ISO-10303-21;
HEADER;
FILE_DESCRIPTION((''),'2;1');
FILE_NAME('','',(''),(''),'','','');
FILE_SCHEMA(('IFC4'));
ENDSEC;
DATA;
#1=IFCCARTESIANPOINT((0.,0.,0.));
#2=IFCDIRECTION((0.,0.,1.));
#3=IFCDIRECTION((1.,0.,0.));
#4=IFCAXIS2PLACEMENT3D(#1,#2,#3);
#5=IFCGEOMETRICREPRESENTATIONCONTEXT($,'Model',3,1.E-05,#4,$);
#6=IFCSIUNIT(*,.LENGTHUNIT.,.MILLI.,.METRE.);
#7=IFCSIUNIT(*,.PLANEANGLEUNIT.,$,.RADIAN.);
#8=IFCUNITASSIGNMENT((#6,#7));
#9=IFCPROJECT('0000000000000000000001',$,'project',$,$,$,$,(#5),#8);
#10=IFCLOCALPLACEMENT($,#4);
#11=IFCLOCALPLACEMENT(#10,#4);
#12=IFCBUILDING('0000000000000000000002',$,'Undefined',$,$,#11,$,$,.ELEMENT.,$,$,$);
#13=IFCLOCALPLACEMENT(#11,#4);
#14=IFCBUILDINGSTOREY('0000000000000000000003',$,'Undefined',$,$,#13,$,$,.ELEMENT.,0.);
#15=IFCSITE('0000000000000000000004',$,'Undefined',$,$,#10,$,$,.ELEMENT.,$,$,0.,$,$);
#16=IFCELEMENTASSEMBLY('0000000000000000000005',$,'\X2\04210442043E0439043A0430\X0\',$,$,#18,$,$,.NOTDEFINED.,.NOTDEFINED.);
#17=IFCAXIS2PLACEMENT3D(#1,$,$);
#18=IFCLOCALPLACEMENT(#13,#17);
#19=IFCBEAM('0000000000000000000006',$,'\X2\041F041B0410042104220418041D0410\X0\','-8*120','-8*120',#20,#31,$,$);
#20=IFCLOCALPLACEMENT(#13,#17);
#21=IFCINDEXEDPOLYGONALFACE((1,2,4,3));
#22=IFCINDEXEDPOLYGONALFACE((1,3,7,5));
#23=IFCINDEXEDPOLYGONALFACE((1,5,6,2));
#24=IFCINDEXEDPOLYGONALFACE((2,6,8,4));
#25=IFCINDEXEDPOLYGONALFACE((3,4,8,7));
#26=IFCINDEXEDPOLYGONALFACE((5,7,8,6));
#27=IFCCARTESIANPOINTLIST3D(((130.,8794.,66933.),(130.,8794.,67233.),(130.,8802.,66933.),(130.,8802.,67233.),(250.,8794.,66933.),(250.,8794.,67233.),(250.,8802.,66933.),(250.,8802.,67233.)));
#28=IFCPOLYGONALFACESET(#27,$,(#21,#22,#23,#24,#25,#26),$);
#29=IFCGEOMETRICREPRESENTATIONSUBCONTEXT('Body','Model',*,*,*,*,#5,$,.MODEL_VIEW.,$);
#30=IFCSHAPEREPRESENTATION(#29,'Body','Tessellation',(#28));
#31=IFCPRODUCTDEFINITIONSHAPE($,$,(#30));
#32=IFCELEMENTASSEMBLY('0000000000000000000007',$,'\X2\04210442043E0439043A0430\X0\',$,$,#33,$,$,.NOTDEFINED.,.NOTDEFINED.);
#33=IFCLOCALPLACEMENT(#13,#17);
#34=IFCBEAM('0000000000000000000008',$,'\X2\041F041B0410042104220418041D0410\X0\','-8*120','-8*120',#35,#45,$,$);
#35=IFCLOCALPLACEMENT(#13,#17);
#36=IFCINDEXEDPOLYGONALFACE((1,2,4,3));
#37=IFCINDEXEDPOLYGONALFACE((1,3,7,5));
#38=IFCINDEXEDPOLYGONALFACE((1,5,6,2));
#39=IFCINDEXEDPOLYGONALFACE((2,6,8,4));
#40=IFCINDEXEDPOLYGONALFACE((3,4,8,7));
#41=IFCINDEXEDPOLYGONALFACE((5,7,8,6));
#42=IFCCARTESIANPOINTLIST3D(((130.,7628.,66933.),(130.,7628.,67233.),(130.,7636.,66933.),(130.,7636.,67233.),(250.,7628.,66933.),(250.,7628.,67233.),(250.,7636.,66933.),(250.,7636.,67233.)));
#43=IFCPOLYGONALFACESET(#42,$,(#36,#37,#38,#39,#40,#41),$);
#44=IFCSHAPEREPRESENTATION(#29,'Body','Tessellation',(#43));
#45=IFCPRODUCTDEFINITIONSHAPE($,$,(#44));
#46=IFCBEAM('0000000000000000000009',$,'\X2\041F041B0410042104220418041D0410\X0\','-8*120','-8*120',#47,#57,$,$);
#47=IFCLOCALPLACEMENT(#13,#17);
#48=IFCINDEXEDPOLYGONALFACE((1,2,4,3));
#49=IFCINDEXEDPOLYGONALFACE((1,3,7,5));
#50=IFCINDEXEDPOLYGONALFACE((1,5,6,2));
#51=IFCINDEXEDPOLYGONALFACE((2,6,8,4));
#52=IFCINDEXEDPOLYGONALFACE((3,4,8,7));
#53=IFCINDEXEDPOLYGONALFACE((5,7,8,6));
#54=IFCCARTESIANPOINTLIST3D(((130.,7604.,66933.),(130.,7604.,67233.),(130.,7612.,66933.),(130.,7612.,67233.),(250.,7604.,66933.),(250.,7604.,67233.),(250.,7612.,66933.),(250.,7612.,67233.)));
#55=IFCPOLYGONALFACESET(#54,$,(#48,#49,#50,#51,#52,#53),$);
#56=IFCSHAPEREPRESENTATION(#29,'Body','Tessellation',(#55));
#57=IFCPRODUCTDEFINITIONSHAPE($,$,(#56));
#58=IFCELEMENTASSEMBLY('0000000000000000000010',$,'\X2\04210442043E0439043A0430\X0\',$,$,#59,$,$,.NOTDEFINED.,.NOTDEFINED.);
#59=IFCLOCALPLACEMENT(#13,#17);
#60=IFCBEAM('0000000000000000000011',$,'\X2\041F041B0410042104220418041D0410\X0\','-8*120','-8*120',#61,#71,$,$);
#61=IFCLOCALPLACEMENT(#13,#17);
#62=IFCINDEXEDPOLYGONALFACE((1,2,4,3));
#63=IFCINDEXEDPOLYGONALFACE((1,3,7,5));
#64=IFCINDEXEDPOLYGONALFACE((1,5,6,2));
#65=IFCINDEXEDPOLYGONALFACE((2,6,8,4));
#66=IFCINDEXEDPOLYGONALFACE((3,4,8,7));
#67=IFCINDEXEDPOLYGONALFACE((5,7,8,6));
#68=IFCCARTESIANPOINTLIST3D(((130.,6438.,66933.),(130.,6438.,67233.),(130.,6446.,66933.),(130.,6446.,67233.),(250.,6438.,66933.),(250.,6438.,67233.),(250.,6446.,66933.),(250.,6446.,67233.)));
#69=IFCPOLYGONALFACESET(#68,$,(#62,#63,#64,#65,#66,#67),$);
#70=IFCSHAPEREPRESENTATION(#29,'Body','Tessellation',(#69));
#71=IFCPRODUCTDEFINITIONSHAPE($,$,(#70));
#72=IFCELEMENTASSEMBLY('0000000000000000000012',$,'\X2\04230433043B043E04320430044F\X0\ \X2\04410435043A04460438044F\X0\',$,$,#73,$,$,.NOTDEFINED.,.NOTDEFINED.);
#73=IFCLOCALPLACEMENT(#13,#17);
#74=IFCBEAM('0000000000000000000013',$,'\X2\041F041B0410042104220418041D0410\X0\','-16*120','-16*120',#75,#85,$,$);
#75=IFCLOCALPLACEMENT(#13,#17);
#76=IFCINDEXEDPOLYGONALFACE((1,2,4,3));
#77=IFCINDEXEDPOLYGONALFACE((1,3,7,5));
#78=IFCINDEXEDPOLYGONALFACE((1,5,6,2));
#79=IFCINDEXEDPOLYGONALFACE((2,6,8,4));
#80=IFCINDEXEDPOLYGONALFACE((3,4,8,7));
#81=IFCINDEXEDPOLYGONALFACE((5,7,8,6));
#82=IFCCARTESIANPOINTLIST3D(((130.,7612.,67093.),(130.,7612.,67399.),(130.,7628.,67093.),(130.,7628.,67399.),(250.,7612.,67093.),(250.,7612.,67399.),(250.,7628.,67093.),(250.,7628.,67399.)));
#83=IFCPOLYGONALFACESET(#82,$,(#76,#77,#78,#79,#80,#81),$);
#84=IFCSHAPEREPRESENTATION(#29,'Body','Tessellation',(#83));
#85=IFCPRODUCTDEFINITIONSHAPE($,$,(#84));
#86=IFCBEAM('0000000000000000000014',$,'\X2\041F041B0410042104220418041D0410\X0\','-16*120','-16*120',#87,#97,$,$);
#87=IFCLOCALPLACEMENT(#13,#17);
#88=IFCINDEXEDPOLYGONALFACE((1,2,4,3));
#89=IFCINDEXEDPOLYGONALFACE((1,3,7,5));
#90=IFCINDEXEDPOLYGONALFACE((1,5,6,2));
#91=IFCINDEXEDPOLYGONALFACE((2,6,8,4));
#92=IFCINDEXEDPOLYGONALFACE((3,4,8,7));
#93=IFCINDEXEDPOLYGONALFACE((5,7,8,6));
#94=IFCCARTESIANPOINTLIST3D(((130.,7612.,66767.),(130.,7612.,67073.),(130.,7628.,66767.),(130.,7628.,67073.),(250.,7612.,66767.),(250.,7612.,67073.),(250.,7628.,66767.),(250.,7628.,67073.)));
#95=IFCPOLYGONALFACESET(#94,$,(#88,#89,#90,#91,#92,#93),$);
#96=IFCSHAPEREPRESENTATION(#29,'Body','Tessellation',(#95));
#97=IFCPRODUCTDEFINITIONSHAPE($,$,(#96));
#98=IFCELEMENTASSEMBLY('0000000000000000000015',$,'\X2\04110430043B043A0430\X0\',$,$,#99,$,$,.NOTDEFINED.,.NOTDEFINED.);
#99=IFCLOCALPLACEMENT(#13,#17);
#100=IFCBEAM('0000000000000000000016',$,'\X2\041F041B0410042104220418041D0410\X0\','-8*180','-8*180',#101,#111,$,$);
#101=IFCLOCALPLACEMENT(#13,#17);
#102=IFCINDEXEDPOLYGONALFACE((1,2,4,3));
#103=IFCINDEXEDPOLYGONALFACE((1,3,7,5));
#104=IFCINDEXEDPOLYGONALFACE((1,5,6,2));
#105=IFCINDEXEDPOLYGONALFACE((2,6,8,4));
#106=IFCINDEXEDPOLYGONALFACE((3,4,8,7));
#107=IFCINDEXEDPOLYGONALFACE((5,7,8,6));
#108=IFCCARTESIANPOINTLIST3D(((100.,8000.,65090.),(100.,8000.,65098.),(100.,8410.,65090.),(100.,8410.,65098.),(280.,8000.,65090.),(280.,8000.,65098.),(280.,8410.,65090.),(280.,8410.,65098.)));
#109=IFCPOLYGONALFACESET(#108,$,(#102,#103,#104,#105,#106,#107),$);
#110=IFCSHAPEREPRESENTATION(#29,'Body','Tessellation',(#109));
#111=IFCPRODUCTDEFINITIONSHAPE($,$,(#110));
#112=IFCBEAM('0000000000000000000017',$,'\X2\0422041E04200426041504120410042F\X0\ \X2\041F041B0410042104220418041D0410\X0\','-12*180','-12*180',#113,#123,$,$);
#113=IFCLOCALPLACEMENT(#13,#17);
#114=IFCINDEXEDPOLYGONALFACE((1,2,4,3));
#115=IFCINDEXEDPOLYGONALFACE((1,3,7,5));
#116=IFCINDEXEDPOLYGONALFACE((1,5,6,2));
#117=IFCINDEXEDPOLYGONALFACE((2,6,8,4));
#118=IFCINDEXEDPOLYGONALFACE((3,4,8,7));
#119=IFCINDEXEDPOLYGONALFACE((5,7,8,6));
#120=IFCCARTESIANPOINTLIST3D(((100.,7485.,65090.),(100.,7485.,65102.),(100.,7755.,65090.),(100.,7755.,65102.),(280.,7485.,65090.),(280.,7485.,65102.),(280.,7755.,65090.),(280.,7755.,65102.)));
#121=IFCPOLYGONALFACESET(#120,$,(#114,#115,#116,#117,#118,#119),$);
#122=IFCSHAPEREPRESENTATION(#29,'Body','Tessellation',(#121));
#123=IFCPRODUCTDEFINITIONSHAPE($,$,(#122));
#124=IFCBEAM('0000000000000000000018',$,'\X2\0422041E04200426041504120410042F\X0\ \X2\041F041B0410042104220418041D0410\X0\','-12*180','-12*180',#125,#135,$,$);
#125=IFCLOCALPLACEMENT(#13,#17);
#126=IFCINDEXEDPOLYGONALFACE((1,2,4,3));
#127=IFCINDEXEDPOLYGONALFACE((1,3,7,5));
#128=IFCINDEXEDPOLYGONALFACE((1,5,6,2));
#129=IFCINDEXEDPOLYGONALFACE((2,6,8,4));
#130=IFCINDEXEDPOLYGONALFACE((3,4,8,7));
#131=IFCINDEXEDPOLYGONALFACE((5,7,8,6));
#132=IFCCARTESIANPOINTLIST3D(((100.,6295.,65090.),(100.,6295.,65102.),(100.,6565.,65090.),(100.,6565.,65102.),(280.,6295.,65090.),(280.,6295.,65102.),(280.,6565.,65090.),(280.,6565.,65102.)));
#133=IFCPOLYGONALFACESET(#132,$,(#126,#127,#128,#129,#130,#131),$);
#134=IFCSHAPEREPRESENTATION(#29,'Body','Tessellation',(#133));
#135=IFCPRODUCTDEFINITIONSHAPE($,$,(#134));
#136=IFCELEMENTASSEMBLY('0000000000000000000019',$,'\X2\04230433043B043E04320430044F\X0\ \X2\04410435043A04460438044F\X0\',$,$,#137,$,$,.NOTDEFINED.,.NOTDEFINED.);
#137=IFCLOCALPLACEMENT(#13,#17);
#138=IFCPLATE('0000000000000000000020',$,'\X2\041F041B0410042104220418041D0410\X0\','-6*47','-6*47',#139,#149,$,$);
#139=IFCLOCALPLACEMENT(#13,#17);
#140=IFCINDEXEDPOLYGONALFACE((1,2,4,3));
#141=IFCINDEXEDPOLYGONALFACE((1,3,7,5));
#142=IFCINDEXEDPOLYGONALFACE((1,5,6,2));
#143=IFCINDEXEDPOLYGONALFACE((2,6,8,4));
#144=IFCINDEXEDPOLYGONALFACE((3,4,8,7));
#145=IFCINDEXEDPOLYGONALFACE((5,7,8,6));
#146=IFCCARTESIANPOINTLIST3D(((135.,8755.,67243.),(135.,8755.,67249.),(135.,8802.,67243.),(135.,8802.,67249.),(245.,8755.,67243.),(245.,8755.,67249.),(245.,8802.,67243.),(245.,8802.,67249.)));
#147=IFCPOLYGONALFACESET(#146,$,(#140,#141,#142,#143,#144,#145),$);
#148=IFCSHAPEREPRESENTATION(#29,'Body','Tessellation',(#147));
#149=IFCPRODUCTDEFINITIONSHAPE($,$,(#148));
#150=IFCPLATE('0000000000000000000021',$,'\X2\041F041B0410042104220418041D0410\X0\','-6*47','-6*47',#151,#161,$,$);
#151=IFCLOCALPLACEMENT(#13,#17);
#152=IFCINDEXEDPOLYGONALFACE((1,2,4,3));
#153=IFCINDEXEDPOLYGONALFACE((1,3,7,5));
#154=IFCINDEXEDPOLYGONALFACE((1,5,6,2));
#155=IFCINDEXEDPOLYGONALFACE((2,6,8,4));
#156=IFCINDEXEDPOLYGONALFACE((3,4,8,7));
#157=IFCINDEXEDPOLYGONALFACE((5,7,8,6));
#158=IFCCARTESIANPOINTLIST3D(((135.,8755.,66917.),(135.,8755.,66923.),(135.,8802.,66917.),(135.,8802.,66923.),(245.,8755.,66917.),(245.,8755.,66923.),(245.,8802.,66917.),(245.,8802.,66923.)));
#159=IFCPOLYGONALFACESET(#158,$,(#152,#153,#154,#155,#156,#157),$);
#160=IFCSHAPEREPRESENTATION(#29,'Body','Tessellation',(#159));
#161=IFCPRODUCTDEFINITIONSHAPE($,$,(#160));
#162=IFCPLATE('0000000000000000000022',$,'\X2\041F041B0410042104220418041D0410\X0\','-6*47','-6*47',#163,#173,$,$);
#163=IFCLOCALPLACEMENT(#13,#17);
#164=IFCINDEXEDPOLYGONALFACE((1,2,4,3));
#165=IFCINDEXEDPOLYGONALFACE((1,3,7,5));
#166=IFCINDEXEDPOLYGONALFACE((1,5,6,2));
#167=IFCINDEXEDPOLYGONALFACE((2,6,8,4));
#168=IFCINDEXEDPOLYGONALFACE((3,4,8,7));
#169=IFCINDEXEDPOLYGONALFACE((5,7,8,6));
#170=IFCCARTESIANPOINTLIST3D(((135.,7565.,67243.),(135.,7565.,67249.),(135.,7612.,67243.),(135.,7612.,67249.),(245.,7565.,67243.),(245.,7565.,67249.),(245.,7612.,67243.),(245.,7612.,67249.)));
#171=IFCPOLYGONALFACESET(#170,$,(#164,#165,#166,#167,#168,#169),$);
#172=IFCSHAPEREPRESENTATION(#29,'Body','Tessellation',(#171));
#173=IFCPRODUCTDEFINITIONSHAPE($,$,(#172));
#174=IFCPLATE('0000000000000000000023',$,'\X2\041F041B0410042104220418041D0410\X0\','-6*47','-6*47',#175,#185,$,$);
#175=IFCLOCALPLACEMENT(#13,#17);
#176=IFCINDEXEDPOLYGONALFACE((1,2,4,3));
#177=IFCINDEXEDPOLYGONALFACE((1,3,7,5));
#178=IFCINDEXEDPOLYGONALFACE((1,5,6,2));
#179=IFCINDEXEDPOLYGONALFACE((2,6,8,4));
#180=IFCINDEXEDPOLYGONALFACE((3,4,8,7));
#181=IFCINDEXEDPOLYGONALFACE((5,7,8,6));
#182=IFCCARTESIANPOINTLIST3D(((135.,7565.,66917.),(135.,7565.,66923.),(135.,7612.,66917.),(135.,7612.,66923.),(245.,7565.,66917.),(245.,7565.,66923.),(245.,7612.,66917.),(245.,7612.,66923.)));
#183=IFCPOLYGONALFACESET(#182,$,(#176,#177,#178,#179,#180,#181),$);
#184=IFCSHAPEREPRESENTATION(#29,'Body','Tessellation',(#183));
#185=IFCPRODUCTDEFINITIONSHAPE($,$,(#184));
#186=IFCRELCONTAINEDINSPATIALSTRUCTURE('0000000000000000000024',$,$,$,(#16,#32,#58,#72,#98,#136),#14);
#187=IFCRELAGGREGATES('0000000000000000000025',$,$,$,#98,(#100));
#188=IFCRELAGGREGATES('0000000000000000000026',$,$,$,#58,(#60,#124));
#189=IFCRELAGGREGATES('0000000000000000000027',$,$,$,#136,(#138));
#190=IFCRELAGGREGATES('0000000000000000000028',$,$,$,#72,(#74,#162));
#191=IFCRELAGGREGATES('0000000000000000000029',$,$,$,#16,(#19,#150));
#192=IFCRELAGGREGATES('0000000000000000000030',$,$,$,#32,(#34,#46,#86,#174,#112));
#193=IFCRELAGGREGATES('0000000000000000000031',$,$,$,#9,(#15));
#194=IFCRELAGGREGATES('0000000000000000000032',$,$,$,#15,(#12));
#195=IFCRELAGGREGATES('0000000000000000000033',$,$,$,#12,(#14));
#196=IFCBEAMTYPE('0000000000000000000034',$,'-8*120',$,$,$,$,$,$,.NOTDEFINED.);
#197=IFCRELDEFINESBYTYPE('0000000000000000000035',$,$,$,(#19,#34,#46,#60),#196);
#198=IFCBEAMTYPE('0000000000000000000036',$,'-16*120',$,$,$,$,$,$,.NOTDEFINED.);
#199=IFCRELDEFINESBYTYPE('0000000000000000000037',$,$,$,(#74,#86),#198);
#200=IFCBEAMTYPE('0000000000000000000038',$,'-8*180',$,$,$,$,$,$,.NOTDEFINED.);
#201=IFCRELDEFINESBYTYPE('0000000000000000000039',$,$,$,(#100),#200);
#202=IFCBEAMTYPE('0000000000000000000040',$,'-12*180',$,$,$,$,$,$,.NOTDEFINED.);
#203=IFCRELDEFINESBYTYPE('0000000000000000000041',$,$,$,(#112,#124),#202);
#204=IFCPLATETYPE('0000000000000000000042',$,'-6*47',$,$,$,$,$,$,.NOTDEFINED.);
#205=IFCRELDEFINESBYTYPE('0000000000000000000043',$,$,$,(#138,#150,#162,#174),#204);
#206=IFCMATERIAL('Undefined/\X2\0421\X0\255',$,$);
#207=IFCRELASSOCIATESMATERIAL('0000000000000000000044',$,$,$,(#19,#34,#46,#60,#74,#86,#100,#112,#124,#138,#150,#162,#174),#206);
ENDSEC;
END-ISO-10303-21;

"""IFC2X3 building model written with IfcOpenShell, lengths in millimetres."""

from ifc_helpers import new_model, si_unit, frame, origin_with_axes, origin_2d_with_axis, place, context, subcontext, project, spatial, polyline, rectangle, outline, extrude, boolean, material, type_object, element, aggregate, save


model = new_model("IFC2X3")

# Units and contexts
model_context = context("Model", 3, precision=1e-05, world=origin_with_axes())
body_context = subcontext(model_context, "Body", "Model", "MODEL_VIEW")
ifc_project = project(units=[si_unit("LENGTHUNIT", "METRE", prefix="MILLI"), si_unit("PLANEANGLEUNIT", "RADIAN")], contexts=[model_context])

# Site, building, storey
site_placement = place(None, origin_with_axes())
site = spatial("IfcSite", under=ifc_project, at=site_placement, Name="Undefined", CompositionType="ELEMENT", RefElevation=0.0)
building_placement = place(site_placement, origin_with_axes())
building = spatial("IfcBuilding", under=site, at=building_placement, Name="Undefined", CompositionType="ELEMENT")
storey_placement = place(building_placement, origin_with_axes())
storey = spatial("IfcBuildingStorey", under=building, at=storey_placement, Name="Undefined", CompositionType="ELEMENT", Elevation=0.0)

# Element assembly, beam
assembly_1_placement = place(storey_placement, origin_with_axes())
assembly_1 = element("IfcElementAssembly", 1, at=assembly_1_placement, inside=storey, Name="Стойка", AssemblyPlace="NOTDEFINED", PredefinedType="NOTDEFINED")
ifc_material_1 = material(Name="Undefined/С255")
beam_type_1 = type_object("IfcBeamType", Name="-8*120", PredefinedType="NOTDEFINED")
beam_1_placement = place(assembly_1_placement, frame((190.0, 8798.0, 66933.0), z_axis=(1.0, 0.0, 0.0), x_axis=(0.0, 0.0, 1.0)))
beam_1 = element("IfcBeam", 2, at=beam_1_placement, type_object=beam_type_1, material=ifc_material_1, Name="ПЛАСТИНА", Description="-8*120", ObjectType="-8*120", context=body_context, shape_type="SweptSolid", body=[
    extrude(rectangle(XDim=8.0, YDim=120.0, at=origin_2d_with_axis()), frame((300.0, 0.0, 0.0), z_axis=(-1.0, 0.0, 0.0), x_axis=(0.0, -1.0, 0.0)), (0.0, 0.0, 1.0), 300.0),
])

# Element assembly, beams
assembly_2_placement = place(storey_placement, origin_with_axes())
assembly_2 = element("IfcElementAssembly", 3, at=assembly_2_placement, inside=storey, Name="Стойка", AssemblyPlace="NOTDEFINED", PredefinedType="NOTDEFINED")
beam_2_placement = place(assembly_2_placement, frame((190.0, 7632.0, 66933.0), z_axis=(1.0, 0.0, 0.0), x_axis=(0.0, 0.0, 1.0)))
beam_2 = element("IfcBeam", 4, at=beam_2_placement, type_object=beam_type_1, material=ifc_material_1, Name="ПЛАСТИНА", Description="-8*120", ObjectType="-8*120", context=body_context, shape_type="SweptSolid", body=[
    extrude(rectangle(XDim=8.0, YDim=120.0, at=origin_2d_with_axis()), frame((300.0, 0.0, 0.0), z_axis=(-1.0, 0.0, 0.0), x_axis=(0.0, -1.0, 0.0)), (0.0, 0.0, 1.0), 300.0),
])
beam_3_placement = place(assembly_2_placement, frame((190.0, 7608.0, 66933.0), z_axis=(1.0, 0.0, 0.0), x_axis=(0.0, 0.0, 1.0)))
beam_3 = element("IfcBeam", 5, at=beam_3_placement, type_object=beam_type_1, material=ifc_material_1, Name="ПЛАСТИНА", Description="-8*120", ObjectType="-8*120", context=body_context, shape_type="SweptSolid", body=[
    extrude(rectangle(XDim=8.0, YDim=120.0, at=origin_2d_with_axis()), frame((300.0, 0.0, 0.0), z_axis=(-1.0, 0.0, 0.0), x_axis=(0.0, -1.0, 0.0)), (0.0, 0.0, 1.0), 300.0),
])

# Element assemblies, beams
assembly_3_placement = place(storey_placement, origin_with_axes())
assembly_3 = element("IfcElementAssembly", 6, at=assembly_3_placement, inside=storey, Name="Стойка", AssemblyPlace="NOTDEFINED", PredefinedType="NOTDEFINED")
beam_4_placement = place(assembly_3_placement, frame((190.0, 6442.0, 66933.0), z_axis=(1.0, 0.0, 0.0), x_axis=(0.0, 0.0, 1.0)))
beam_4 = element("IfcBeam", 7, at=beam_4_placement, type_object=beam_type_1, material=ifc_material_1, Name="ПЛАСТИНА", Description="-8*120", ObjectType="-8*120", context=body_context, shape_type="SweptSolid", body=[
    extrude(rectangle(XDim=8.0, YDim=120.0, at=origin_2d_with_axis()), frame((300.0, 0.0, 0.0), z_axis=(-1.0, 0.0, 0.0), x_axis=(0.0, -1.0, 0.0)), (0.0, 0.0, 1.0), 300.0),
])
assembly_4_placement = place(storey_placement, origin_with_axes())
assembly_4 = element("IfcElementAssembly", 8, at=assembly_4_placement, inside=storey, Name="Угловая секция", AssemblyPlace="NOTDEFINED", PredefinedType="NOTDEFINED")
beam_type_2 = type_object("IfcBeamType", Name="-16*120", PredefinedType="NOTDEFINED")
beam_5_placement = place(assembly_4_placement, frame((190.0, 7620.0, 67093.0), z_axis=(1.0, 0.0, 0.0), x_axis=(0.0, 0.0, 1.0)))
beam_5 = element("IfcBeam", 9, at=beam_5_placement, type_object=beam_type_2, material=ifc_material_1, Name="ПЛАСТИНА", Description="-16*120", ObjectType="-16*120", context=body_context, shape_type="SweptSolid", body=[
    extrude(rectangle(XDim=16.0, YDim=120.0, at=origin_2d_with_axis()), frame((306.0, 0.0, 0.0), z_axis=(-1.0, 0.0, 0.0), x_axis=(0.0, -1.0, 0.0)), (0.0, 0.0, 1.0), 306.0),
])

# Beam
beam_6_placement = place(assembly_2_placement, frame((190.0, 7620.0, 66767.0), z_axis=(1.0, 0.0, 0.0), x_axis=(0.0, 0.0, 1.0)))
beam_6 = element("IfcBeam", 10, at=beam_6_placement, type_object=beam_type_2, material=ifc_material_1, Name="ПЛАСТИНА", Description="-16*120", ObjectType="-16*120", context=body_context, shape_type="SweptSolid", body=[
    extrude(rectangle(XDim=16.0, YDim=120.0, at=origin_2d_with_axis()), frame((306.0, 0.0, 0.0), z_axis=(-1.0, 0.0, 0.0), x_axis=(0.0, -1.0, 0.0)), (0.0, 0.0, 1.0), 306.0),
])

# Element assembly, beam
assembly_5_placement = place(storey_placement, origin_with_axes())
assembly_5 = element("IfcElementAssembly", 11, at=assembly_5_placement, inside=storey, Name="Балка", AssemblyPlace="NOTDEFINED", PredefinedType="NOTDEFINED")
beam_type_3 = type_object("IfcBeamType", Name="-8*180", PredefinedType="NOTDEFINED")
beam_7_placement = place(assembly_5_placement, frame((190.0, 8410.0, 65094.0), z_axis=(-1.0, 0.0, 0.0), x_axis=(0.0, -1.0, 0.0)))
beam_7 = element("IfcBeam", 12, at=beam_7_placement, type_object=beam_type_3, material=ifc_material_1, Name="ПЛАСТИНА", Description="-8*180", ObjectType="-8*180", context=body_context, shape_type="SweptSolid", body=[
    extrude(rectangle(XDim=8.0, YDim=180.0, at=origin_2d_with_axis()), frame((410.0, 0.0, 0.0), z_axis=(-1.0, 0.0, 0.0), x_axis=(0.0, -1.0, 0.0)), (0.0, 0.0, 1.0), 410.0),
])
aggregate(assembly_5, [beam_7])

# Beams
beam_type_4 = type_object("IfcBeamType", Name="-12*180", PredefinedType="NOTDEFINED")
beam_8_placement = place(assembly_2_placement, frame((190.0, 7755.0, 65096.0), z_axis=(1.0, 0.0, 0.0), x_axis=(0.0, -1.0, 0.0)))
beam_8 = element("IfcBeam", 13, at=beam_8_placement, type_object=beam_type_4, material=ifc_material_1, Name="ТОРЦЕВАЯ ПЛАСТИНА", Description="-12*180", ObjectType="-12*180", context=body_context, shape_type="SweptSolid", body=[
    extrude(rectangle(XDim=12.0, YDim=180.0, at=origin_2d_with_axis()), frame((270.0, 0.0, 0.0), z_axis=(-1.0, 0.0, 0.0), x_axis=(0.0, -1.0, 0.0)), (0.0, 0.0, 1.0), 270.0),
])
beam_9_placement = place(assembly_3_placement, frame((190.0, 6565.0, 65096.0), z_axis=(1.0, 0.0, 0.0), x_axis=(0.0, -1.0, 0.0)))
beam_9 = element("IfcBeam", 14, at=beam_9_placement, type_object=beam_type_4, material=ifc_material_1, Name="ТОРЦЕВАЯ ПЛАСТИНА", Description="-12*180", ObjectType="-12*180", context=body_context, shape_type="SweptSolid", body=[
    extrude(rectangle(XDim=12.0, YDim=180.0, at=origin_2d_with_axis()), frame((270.0, 0.0, 0.0), z_axis=(-1.0, 0.0, 0.0), x_axis=(0.0, -1.0, 0.0)), (0.0, 0.0, 1.0), 270.0),
])
aggregate(assembly_3, [beam_4, beam_9])

# Element assembly, plate
assembly_6_placement = place(storey_placement, origin_with_axes())
assembly_6 = element("IfcElementAssembly", 15, at=assembly_6_placement, inside=storey, Name="Угловая секция", AssemblyPlace="NOTDEFINED", PredefinedType="NOTDEFINED")
plate_type = type_object("IfcPlateType", Name="-6*47", PredefinedType="NOTDEFINED")
plate_1_placement = place(assembly_6_placement, frame((245.0, 8755.0, 67246.0), z_axis=(0.0, 0.0, -1.0), x_axis=(-1.0, 0.0, 0.0)))
plate_1 = element("IfcPlate", 16, at=plate_1_placement, type_object=plate_type, material=ifc_material_1, Name="ПЛАСТИНА", Description="-6*47", ObjectType="-6*47", context=body_context, shape_type="CSG", body=[
    boolean("DIFFERENCE", extrude(outline(polyline([(0.0, 0.0), (110.0, 0.0), (110.0, 110.0), (0.0, 110.0), (0.0, 0.0)])), frame((0.0, 0.0, -3.0), z_axis=(0.0, 0.0, 1.0), x_axis=(1.0, 0.0, 0.0)), (0.0, 0.0, 1.0), 6.0), extrude(rectangle(XDim=26.0, YDim=130.0, at=origin_2d_with_axis()), frame((55.0, 47.0, 0.0), z_axis=(0.0, 1.0, 0.0), x_axis=(0.0, 0.0, -1.0)), (0.0, 0.0, 1.0), 66.0)),
])
aggregate(assembly_6, [plate_1])

# Plates
plate_2_placement = place(assembly_1_placement, frame((135.0, 8755.0, 66920.0), z_axis=(0.0, 0.0, 1.0), x_axis=(1.0, 0.0, 0.0)))
plate_2 = element("IfcPlate", 17, at=plate_2_placement, type_object=plate_type, material=ifc_material_1, Name="ПЛАСТИНА", Description="-6*47", ObjectType="-6*47", context=body_context, shape_type="CSG", body=[
    boolean("DIFFERENCE", extrude(outline(polyline([(0.0, 0.0), (110.0, 0.0), (110.0, 110.0), (0.0, 110.0), (0.0, 0.0)])), frame((0.0, 0.0, -3.0), z_axis=(0.0, 0.0, 1.0), x_axis=(1.0, 0.0, 0.0)), (0.0, 0.0, 1.0), 6.0), extrude(rectangle(XDim=26.0, YDim=130.0, at=origin_2d_with_axis()), frame((55.0, 47.0, 0.0), z_axis=(0.0, 1.0, 0.0), x_axis=(0.0, 0.0, -1.0)), (0.0, 0.0, 1.0), 66.0)),
])
plate_3_placement = place(assembly_4_placement, frame((245.0, 7565.0, 67246.0), z_axis=(0.0, 0.0, -1.0), x_axis=(-1.0, 0.0, 0.0)))
plate_3 = element("IfcPlate", 18, at=plate_3_placement, type_object=plate_type, material=ifc_material_1, Name="ПЛАСТИНА", Description="-6*47", ObjectType="-6*47", context=body_context, shape_type="CSG", body=[
    boolean("DIFFERENCE", extrude(outline(polyline([(0.0, 0.0), (110.0, 0.0), (110.0, 110.0), (0.0, 110.0), (0.0, 0.0)])), frame((0.0, 0.0, -3.0), z_axis=(0.0, 0.0, 1.0), x_axis=(1.0, 0.0, 0.0)), (0.0, 0.0, 1.0), 6.0), extrude(rectangle(XDim=26.0, YDim=130.0, at=origin_2d_with_axis()), frame((55.0, 47.0, 0.0), z_axis=(0.0, 1.0, 0.0), x_axis=(0.0, 0.0, -1.0)), (0.0, 0.0, 1.0), 66.0)),
])
aggregate(assembly_4, [beam_5, plate_3])
plate_4_placement = place(assembly_2_placement, frame((135.0, 7565.0, 66920.0), z_axis=(0.0, 0.0, 1.0), x_axis=(1.0, 0.0, 0.0)))
plate_4 = element("IfcPlate", 19, at=plate_4_placement, type_object=plate_type, material=ifc_material_1, Name="ПЛАСТИНА", Description="-6*47", ObjectType="-6*47", context=body_context, shape_type="CSG", body=[
    boolean("DIFFERENCE", extrude(outline(polyline([(0.0, 0.0), (110.0, 0.0), (110.0, 110.0), (0.0, 110.0), (0.0, 0.0)])), frame((0.0, 0.0, -3.0), z_axis=(0.0, 0.0, 1.0), x_axis=(1.0, 0.0, 0.0)), (0.0, 0.0, 1.0), 6.0), extrude(rectangle(XDim=26.0, YDim=130.0, at=origin_2d_with_axis()), frame((55.0, 47.0, 0.0), z_axis=(0.0, 1.0, 0.0), x_axis=(0.0, 0.0, -1.0)), (0.0, 0.0, 1.0), 66.0)),
])

aggregate(assembly_1, [beam_1, plate_2])
aggregate(assembly_2, [beam_2, beam_3, beam_6, plate_4, beam_8])

save(model, "model.ifc")
